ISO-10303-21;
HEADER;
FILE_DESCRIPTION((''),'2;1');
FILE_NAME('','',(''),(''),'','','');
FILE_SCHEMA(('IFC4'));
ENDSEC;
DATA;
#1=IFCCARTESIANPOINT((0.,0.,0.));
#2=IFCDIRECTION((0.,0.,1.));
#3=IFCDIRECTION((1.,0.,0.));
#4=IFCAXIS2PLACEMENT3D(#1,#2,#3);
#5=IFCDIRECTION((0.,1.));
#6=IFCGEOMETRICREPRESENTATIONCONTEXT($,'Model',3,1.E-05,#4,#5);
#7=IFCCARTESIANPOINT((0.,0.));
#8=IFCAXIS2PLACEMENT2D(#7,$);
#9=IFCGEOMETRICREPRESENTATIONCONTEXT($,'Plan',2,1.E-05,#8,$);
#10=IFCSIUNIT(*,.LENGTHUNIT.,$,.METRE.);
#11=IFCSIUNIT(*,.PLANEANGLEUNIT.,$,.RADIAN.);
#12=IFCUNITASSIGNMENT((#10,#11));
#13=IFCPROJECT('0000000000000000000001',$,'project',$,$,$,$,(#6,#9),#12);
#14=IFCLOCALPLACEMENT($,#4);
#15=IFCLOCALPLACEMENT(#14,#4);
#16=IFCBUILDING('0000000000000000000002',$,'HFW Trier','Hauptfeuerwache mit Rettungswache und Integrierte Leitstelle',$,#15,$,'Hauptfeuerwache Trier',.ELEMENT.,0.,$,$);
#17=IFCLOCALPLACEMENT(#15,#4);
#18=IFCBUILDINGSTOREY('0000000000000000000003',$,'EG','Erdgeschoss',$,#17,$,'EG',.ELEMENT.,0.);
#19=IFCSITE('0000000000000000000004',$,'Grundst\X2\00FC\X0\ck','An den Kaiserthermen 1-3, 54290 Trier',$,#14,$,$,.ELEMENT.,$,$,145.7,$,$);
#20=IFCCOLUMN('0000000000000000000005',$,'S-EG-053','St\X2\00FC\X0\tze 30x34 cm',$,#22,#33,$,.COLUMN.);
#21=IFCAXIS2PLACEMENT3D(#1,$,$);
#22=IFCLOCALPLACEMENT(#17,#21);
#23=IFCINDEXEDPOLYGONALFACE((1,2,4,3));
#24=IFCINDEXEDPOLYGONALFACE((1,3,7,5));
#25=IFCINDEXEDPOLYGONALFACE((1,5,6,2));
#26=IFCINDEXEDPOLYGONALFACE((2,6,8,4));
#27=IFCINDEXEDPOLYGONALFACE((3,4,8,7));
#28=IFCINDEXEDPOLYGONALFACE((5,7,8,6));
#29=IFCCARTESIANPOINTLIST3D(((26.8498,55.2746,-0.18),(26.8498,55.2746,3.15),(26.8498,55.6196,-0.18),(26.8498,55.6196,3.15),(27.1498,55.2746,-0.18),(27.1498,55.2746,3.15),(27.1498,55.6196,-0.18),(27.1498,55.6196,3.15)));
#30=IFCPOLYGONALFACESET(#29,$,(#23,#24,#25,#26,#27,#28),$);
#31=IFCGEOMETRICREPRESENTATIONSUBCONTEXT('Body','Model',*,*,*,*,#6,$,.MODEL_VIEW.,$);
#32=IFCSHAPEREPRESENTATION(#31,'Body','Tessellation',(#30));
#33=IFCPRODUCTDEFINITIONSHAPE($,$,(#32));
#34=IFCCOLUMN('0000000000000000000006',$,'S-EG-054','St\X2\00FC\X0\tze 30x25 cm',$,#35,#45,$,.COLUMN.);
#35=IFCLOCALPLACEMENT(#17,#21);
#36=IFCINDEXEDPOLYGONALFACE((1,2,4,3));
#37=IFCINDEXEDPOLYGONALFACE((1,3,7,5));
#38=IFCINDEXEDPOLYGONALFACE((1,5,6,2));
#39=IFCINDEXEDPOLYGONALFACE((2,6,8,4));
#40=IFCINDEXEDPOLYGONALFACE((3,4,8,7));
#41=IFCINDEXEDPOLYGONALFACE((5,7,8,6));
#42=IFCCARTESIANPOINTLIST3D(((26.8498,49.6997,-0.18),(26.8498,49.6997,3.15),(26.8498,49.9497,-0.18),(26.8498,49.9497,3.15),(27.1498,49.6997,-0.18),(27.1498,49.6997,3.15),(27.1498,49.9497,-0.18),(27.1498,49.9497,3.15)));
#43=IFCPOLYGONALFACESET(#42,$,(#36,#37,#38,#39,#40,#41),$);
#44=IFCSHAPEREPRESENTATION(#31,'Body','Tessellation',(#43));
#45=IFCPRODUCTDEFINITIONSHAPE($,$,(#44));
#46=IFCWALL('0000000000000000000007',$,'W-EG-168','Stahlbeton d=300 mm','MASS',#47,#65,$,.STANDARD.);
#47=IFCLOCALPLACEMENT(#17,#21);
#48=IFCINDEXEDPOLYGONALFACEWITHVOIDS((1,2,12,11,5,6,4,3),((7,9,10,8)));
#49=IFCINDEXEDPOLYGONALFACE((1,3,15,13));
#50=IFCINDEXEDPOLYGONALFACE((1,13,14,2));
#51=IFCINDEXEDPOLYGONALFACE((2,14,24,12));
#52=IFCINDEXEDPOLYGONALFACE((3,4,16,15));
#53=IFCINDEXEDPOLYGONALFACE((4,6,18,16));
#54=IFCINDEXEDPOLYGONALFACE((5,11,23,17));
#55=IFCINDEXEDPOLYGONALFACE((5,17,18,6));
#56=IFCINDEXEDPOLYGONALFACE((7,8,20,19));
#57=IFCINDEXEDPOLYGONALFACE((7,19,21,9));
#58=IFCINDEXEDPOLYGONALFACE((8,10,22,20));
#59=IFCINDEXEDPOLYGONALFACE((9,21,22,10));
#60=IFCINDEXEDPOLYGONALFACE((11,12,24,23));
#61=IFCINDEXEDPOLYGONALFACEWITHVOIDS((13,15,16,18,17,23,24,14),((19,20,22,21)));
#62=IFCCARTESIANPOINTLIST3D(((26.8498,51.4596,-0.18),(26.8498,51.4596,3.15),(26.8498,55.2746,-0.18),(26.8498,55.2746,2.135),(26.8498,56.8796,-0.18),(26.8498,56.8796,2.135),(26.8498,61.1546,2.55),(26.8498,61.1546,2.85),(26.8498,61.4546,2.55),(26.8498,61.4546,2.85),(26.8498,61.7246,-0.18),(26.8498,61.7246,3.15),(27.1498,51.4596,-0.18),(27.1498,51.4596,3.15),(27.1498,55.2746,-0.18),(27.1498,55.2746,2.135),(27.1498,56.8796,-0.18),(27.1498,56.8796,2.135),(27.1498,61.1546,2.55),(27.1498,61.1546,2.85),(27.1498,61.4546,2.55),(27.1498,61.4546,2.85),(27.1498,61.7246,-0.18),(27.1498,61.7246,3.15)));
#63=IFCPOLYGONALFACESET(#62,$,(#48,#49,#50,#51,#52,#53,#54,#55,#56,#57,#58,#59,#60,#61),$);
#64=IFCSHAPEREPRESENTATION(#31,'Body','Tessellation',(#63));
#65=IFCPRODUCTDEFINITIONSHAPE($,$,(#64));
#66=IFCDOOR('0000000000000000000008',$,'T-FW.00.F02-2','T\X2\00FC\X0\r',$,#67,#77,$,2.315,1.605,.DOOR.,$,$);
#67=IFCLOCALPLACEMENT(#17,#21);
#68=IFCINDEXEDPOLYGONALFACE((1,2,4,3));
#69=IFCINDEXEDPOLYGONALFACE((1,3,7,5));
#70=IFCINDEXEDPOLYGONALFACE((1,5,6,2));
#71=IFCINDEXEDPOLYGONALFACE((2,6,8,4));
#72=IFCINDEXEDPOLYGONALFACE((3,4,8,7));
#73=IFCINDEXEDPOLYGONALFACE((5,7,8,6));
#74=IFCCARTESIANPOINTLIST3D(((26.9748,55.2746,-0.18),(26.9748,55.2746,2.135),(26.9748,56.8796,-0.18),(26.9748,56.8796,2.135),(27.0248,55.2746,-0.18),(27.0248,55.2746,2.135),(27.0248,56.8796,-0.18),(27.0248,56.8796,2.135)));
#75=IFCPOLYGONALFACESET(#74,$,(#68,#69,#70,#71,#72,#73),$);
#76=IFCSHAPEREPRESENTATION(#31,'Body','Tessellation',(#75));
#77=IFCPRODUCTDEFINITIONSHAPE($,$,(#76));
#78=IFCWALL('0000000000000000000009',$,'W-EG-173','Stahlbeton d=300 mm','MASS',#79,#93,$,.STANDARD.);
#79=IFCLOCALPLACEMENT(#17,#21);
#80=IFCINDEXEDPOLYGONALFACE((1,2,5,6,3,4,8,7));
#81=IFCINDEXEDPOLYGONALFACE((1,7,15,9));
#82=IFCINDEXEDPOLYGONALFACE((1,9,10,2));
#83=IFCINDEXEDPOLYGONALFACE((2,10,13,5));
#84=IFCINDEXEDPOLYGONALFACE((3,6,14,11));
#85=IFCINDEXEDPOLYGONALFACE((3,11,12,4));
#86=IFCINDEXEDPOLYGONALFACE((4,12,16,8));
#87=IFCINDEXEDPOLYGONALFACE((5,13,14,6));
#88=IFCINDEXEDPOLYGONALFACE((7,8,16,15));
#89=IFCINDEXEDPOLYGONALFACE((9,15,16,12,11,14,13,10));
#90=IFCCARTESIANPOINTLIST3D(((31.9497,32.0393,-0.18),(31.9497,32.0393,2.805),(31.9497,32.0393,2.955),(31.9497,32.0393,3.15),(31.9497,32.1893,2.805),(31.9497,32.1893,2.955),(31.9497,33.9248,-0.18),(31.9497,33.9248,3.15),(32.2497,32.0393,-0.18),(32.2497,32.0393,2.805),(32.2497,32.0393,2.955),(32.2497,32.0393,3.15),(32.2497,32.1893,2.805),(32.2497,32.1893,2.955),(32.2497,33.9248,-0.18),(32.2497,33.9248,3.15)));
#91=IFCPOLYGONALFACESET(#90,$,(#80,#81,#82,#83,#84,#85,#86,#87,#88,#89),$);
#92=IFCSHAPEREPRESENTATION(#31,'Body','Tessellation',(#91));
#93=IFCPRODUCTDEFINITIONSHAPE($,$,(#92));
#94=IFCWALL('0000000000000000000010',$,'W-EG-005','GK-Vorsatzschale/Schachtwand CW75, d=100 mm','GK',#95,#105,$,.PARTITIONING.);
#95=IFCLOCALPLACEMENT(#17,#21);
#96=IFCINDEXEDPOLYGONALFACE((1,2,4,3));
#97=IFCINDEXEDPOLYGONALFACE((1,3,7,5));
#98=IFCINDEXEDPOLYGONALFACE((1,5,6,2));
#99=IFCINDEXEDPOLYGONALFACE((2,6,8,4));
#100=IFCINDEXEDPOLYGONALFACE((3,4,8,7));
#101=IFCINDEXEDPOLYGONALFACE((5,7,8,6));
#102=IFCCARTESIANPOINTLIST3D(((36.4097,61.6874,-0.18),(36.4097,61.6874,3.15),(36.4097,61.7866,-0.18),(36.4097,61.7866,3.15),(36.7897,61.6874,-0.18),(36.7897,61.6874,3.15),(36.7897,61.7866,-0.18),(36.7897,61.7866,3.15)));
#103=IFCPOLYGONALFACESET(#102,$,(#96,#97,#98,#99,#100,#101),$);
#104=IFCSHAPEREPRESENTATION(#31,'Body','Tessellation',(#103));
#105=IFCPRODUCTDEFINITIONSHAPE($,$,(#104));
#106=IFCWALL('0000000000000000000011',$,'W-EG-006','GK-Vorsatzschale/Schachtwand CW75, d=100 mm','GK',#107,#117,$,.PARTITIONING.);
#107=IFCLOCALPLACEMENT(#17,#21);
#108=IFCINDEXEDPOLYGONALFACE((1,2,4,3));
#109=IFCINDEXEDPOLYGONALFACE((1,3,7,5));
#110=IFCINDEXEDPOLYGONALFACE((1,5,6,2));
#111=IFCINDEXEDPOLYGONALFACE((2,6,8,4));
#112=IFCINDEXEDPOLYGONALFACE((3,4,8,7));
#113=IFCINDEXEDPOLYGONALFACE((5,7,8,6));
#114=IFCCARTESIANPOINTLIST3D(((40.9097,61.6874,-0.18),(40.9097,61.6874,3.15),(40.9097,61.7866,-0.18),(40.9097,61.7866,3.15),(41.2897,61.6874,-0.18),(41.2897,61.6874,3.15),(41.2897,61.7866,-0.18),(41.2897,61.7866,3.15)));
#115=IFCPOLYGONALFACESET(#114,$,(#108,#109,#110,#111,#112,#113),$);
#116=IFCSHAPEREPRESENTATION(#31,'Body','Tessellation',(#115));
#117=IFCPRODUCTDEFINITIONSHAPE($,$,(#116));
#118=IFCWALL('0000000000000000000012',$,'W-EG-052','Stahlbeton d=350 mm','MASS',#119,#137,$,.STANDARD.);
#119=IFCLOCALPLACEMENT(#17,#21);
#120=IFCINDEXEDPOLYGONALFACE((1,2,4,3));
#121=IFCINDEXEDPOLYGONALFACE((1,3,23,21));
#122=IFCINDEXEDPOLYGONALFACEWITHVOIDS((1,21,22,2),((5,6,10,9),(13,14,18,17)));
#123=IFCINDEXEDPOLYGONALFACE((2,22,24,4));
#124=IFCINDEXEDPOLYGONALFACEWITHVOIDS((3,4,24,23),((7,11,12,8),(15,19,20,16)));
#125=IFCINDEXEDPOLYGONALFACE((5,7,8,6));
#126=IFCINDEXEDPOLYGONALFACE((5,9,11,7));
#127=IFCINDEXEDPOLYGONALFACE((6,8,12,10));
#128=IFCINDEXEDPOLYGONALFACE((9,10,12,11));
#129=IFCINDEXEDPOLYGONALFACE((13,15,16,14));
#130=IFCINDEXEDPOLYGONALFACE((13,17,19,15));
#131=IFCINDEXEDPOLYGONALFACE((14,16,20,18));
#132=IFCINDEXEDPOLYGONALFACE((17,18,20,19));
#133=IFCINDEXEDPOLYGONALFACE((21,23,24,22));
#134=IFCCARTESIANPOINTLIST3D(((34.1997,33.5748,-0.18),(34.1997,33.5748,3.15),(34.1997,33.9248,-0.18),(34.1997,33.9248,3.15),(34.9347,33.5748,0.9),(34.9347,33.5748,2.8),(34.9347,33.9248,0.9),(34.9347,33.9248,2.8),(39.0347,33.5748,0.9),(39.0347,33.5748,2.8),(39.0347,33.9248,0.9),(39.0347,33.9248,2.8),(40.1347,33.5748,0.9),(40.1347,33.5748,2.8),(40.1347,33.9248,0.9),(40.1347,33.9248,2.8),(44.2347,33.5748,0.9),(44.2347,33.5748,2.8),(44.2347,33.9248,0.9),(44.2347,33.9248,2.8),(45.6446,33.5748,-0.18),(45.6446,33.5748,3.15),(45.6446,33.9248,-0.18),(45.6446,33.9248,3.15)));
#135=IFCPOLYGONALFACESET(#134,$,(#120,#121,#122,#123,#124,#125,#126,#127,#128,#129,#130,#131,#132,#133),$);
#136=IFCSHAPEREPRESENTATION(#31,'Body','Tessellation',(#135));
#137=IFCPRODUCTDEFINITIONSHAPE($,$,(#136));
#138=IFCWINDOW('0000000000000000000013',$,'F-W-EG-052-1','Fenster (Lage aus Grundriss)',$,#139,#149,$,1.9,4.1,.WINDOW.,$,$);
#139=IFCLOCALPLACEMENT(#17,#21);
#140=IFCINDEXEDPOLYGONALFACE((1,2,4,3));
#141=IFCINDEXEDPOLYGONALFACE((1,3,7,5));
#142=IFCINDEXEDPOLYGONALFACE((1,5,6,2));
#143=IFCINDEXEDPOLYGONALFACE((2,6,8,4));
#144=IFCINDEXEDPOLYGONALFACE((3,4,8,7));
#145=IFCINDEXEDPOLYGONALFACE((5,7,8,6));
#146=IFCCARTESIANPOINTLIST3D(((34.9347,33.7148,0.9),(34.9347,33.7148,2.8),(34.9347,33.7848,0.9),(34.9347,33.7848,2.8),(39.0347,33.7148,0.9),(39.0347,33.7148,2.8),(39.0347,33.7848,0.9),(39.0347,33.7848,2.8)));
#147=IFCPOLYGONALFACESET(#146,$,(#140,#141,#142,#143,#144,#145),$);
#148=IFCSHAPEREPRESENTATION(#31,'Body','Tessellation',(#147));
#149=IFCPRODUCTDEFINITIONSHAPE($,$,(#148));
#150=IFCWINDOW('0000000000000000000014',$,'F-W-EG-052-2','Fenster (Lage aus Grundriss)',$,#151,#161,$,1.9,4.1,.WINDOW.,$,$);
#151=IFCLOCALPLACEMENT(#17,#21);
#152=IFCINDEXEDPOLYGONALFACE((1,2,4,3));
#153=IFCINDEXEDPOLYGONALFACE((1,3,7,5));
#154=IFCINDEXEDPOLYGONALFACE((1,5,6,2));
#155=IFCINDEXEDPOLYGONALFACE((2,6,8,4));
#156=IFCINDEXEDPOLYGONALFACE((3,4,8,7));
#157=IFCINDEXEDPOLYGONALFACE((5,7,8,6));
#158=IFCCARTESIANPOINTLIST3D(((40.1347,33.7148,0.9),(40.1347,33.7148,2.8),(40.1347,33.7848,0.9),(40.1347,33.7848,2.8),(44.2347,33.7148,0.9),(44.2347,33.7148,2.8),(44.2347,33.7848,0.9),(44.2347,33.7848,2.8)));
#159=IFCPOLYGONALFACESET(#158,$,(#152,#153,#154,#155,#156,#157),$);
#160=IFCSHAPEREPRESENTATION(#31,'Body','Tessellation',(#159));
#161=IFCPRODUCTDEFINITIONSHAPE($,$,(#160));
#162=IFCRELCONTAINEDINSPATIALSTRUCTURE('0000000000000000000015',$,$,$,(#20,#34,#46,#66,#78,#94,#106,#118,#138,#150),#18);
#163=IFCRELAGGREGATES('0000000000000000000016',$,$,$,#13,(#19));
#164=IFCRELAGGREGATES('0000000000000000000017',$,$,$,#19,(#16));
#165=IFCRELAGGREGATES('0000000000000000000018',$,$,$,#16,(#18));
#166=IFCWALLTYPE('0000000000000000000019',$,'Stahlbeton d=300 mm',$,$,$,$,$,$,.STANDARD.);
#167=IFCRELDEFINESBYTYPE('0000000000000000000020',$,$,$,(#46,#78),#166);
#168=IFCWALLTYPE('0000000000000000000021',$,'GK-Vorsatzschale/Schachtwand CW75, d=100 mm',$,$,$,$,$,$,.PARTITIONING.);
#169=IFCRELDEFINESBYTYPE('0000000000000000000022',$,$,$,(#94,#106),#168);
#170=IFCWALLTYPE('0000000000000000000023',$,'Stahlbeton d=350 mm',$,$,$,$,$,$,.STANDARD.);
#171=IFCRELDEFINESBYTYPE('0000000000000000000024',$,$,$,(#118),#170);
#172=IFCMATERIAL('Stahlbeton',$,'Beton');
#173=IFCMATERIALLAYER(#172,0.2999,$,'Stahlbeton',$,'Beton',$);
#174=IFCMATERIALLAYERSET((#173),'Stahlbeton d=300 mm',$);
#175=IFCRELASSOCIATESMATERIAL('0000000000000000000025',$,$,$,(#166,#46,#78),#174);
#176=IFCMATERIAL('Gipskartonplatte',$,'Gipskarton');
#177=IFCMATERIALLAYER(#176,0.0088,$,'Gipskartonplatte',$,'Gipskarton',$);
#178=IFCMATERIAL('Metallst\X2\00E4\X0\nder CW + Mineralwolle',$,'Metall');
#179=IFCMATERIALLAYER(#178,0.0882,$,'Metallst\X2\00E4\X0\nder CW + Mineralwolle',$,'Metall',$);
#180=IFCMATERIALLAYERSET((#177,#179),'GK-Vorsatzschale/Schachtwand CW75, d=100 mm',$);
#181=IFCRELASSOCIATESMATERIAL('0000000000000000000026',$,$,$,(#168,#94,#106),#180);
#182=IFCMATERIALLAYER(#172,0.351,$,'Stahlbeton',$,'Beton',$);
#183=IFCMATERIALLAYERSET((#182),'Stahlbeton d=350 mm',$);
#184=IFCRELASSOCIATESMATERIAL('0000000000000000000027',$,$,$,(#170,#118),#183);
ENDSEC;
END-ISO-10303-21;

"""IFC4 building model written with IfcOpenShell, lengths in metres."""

from ifc_helpers import new_model, si_unit, direction, frame, frame_2d, origin_with_axes, origin_2d, place, context, subcontext, project, spatial, rectangle, extrude, material, layer, layer_set, layer_usage, type_object, element, fill, save


model = new_model("IFC4")

# Units and contexts
model_context = context("Model", 3, precision=1e-05, world=origin_with_axes(), true_north=direction((0.0, 1.0)))
plan_context = context("Plan", 2, precision=1e-05, world=origin_2d())
body_context = subcontext(model_context, "Body", "Model", "MODEL_VIEW")
ifc_project = project(units=[si_unit("LENGTHUNIT", "METRE"), si_unit("PLANEANGLEUNIT", "RADIAN")], contexts=[model_context, plan_context])

# Site, building, storey
site_placement = place(None, origin_with_axes())
site = spatial("IfcSite", under=ifc_project, at=site_placement, Name="Grundstück", Description="An den Kaiserthermen 1-3, 54290 Trier", CompositionType="ELEMENT", RefElevation=145.7)
building_placement = place(site_placement, origin_with_axes())
building = spatial("IfcBuilding", under=site, at=building_placement, Name="HFW Trier", Description="Hauptfeuerwache mit Rettungswache und Integrierte Leitstelle", LongName="Hauptfeuerwache Trier", CompositionType="ELEMENT", ElevationOfRefHeight=0.0)
storey_placement = place(building_placement, origin_with_axes())
storey = spatial("IfcBuildingStorey", under=building, at=storey_placement, Name="EG", Description="Erdgeschoss", LongName="EG", CompositionType="ELEMENT", Elevation=0.0)

# Columns
column_1_placement = place(storey_placement, frame((26.8498, 55.4471, -0.18), z_axis=(0.0, 0.0, 1.0), x_axis=(1.0, 0.0, 0.0)))
element("IfcColumn", 1, at=column_1_placement, inside=storey, Name="S-EG-053", Description="Stütze 30x34 cm", PredefinedType="COLUMN", context=body_context, shape_type="SweptSolid", body=[
    extrude(rectangle(XDim=0.3, YDim=0.345, at=frame_2d((0.15, 0.0))), origin_with_axes(), (0.0, 0.0, 1.0), 3.33),
])
column_2_placement = place(storey_placement, frame((26.8498, 49.8247, -0.18), z_axis=(0.0, 0.0, 1.0), x_axis=(1.0, 0.0, 0.0)))
element("IfcColumn", 2, at=column_2_placement, inside=storey, Name="S-EG-054", Description="Stütze 30x25 cm", PredefinedType="COLUMN", context=body_context, shape_type="SweptSolid", body=[
    extrude(rectangle(XDim=0.3, YDim=0.25, at=frame_2d((0.15, 0.0))), origin_with_axes(), (0.0, 0.0, 1.0), 3.33),
])

# Wall, openings, door
ifc_material_1 = material(Name="Stahlbeton", Category="Beton")
ifc_layer_1 = layer(ifc_material_1, 0.2999, Name="Stahlbeton", Category="Beton")
ifc_layer_set_1 = layer_set([ifc_layer_1], Name="Stahlbeton d=300 mm")
ifc_layer_usage_1 = layer_usage(ifc_layer_set_1, "AXIS2", "POSITIVE", -0.15)
wall_type_1 = type_object("IfcWallType", Name="Stahlbeton d=300 mm", PredefinedType="STANDARD", material=ifc_layer_set_1)
wall_1_placement = place(storey_placement, frame((26.9998, 61.7246, -0.18), z_axis=(0.0, 0.0, 1.0), x_axis=(0.0, -1.0, 0.0)))
wall_1 = element("IfcWall", 3, at=wall_1_placement, inside=storey, type_object=wall_type_1, material=ifc_layer_usage_1, Name="W-EG-168", Description="Stahlbeton d=300 mm", ObjectType="MASS", PredefinedType="STANDARD", context=body_context, shape_type="SweptSolid", body=[
    extrude(rectangle(XDim=10.265, YDim=0.3, at=frame_2d((5.1325, 0.0))), origin_with_axes(), (0.0, 0.0, 1.0), 3.33),
])
opening_1_placement = place(wall_1_placement, frame((4.845, 0.0, 0.0), z_axis=(0.0, 0.0, 1.0), x_axis=(1.0, 0.0, 0.0)))
opening_1 = element("IfcOpeningElement", 4, at=opening_1_placement, cuts=wall_1, PredefinedType="OPENING", context=body_context, shape_type="SweptSolid", body=[
    extrude(rectangle(XDim=1.605, YDim=0.4, at=frame_2d((0.8025, 0.0))), origin_with_axes(), (0.0, 0.0, 1.0), 2.315),
])
opening_2_placement = place(wall_1_placement, origin_with_axes())
element("IfcOpeningElement", 5, at=opening_2_placement, cuts=wall_1, ObjectType="Wanddurchbruch", PredefinedType="OPENING", context=body_context, shape_type="SweptSolid", body=[
    extrude(rectangle(XDim=0.3, YDim=0.4, at=frame_2d((0.42, 0.0))), frame((0.0, 0.0, 2.73), z_axis=(0.0, 0.0, 1.0), x_axis=(1.0, 0.0, 0.0)), (0.0, 0.0, 1.0), 0.3),
])
door_placement = place(wall_1_placement, frame((4.845, 0.0, 0.0), z_axis=(0.0, 0.0, 1.0), x_axis=(1.0, 0.0, 0.0)))
door = element("IfcDoor", 6, at=door_placement, inside=storey, Name="T-FW.00.F02-2", Description="Tür", OverallHeight=2.315, OverallWidth=1.605, PredefinedType="DOOR", context=body_context, shape_type="SweptSolid", body=[
    extrude(rectangle(XDim=1.605, YDim=0.05, at=frame_2d((0.8025, 0.0))), origin_with_axes(), (0.0, 0.0, 1.0), 2.315),
])
fill(opening_1, door)

# Wall, opening
ifc_layer_usage_2 = layer_usage(ifc_layer_set_1, "AXIS2", "POSITIVE", -0.15)
wall_2_placement = place(storey_placement, frame((32.0997, 33.9248, -0.18), z_axis=(0.0, 0.0, 1.0), x_axis=(0.0, -1.0, 0.0)))
wall_2 = element("IfcWall", 7, at=wall_2_placement, inside=storey, type_object=wall_type_1, material=ifc_layer_usage_2, Name="W-EG-173", Description="Stahlbeton d=300 mm", ObjectType="MASS", PredefinedType="STANDARD", context=body_context, shape_type="SweptSolid", body=[
    extrude(rectangle(XDim=1.8855, YDim=0.3, at=frame_2d((0.9428, 0.0))), origin_with_axes(), (0.0, 0.0, 1.0), 3.33),
])
opening_3_placement = place(wall_2_placement, origin_with_axes())
element("IfcOpeningElement", 8, at=opening_3_placement, cuts=wall_2, ObjectType="Wanddurchbruch", PredefinedType="OPENING", context=body_context, shape_type="SweptSolid", body=[
    extrude(rectangle(XDim=0.15, YDim=0.4, at=frame_2d((1.8105, 0.0))), frame((0.0, 0.0, 2.985), z_axis=(0.0, 0.0, 1.0), x_axis=(1.0, 0.0, 0.0)), (0.0, 0.0, 1.0), 0.15),
])

# Walls
ifc_material_2 = material(Name="Gipskartonplatte", Category="Gipskarton")
ifc_layer_2 = layer(ifc_material_2, 0.0088, Name="Gipskartonplatte", Category="Gipskarton")
ifc_material_3 = material(Name="Metallständer CW + Mineralwolle", Category="Metall")
ifc_layer_3 = layer(ifc_material_3, 0.0882, Name="Metallständer CW + Mineralwolle", Category="Metall")
ifc_layer_set_2 = layer_set([ifc_layer_2, ifc_layer_3], Name="GK-Vorsatzschale/Schachtwand CW75, d=100 mm")
ifc_layer_usage_3 = layer_usage(ifc_layer_set_2, "AXIS2", "POSITIVE", -0.0495)
wall_type_2 = type_object("IfcWallType", Name="GK-Vorsatzschale/Schachtwand CW75, d=100 mm", PredefinedType="PARTITIONING", material=ifc_layer_set_2)
wall_3_placement = place(storey_placement, frame((36.4097, 61.737, -0.18), z_axis=(0.0, 0.0, 1.0), x_axis=(1.0, 0.0, 0.0)))
element("IfcWall", 9, at=wall_3_placement, inside=storey, type_object=wall_type_2, material=ifc_layer_usage_3, Name="W-EG-005", Description="GK-Vorsatzschale/Schachtwand CW75, d=100 mm", ObjectType="GK", PredefinedType="PARTITIONING", context=body_context, shape_type="SweptSolid", body=[
    extrude(rectangle(XDim=0.38, YDim=0.0991, at=frame_2d((0.19, 0.0))), origin_with_axes(), (0.0, 0.0, 1.0), 3.33),
])
ifc_layer_usage_4 = layer_usage(ifc_layer_set_2, "AXIS2", "POSITIVE", -0.0495)
wall_4_placement = place(storey_placement, frame((40.9097, 61.737, -0.18), z_axis=(0.0, 0.0, 1.0), x_axis=(1.0, 0.0, 0.0)))
element("IfcWall", 10, at=wall_4_placement, inside=storey, type_object=wall_type_2, material=ifc_layer_usage_4, Name="W-EG-006", Description="GK-Vorsatzschale/Schachtwand CW75, d=100 mm", ObjectType="GK", PredefinedType="PARTITIONING", context=body_context, shape_type="SweptSolid", body=[
    extrude(rectangle(XDim=0.38, YDim=0.0991, at=frame_2d((0.19, 0.0))), origin_with_axes(), (0.0, 0.0, 1.0), 3.33),
])

# Wall, openings, windows
ifc_layer_4 = layer(ifc_material_1, 0.351, Name="Stahlbeton", Category="Beton")
ifc_layer_set_3 = layer_set([ifc_layer_4], Name="Stahlbeton d=350 mm")
ifc_layer_usage_5 = layer_usage(ifc_layer_set_3, "AXIS2", "POSITIVE", -0.175)
wall_type_3 = type_object("IfcWallType", Name="Stahlbeton d=350 mm", PredefinedType="STANDARD", material=ifc_layer_set_3)
wall_5_placement = place(storey_placement, frame((34.1997, 33.7498, -0.18), z_axis=(0.0, 0.0, 1.0), x_axis=(1.0, 0.0, 0.0)))
wall_5 = element("IfcWall", 11, at=wall_5_placement, inside=storey, type_object=wall_type_3, material=ifc_layer_usage_5, Name="W-EG-052", Description="Stahlbeton d=350 mm", ObjectType="MASS", PredefinedType="STANDARD", context=body_context, shape_type="SweptSolid", body=[
    extrude(rectangle(XDim=11.4449, YDim=0.35, at=frame_2d((5.7224, 0.0))), origin_with_axes(), (0.0, 0.0, 1.0), 3.33),
])
opening_4_placement = place(wall_5_placement, frame((0.735, 0.0, 0.0), z_axis=(0.0, 0.0, 1.0), x_axis=(1.0, 0.0, 0.0)))
opening_4 = element("IfcOpeningElement", 12, at=opening_4_placement, cuts=wall_5, PredefinedType="OPENING", context=body_context, shape_type="SweptSolid", body=[
    extrude(rectangle(XDim=4.1, YDim=0.45, at=frame_2d((2.05, 0.0))), frame((0.0, 0.0, 1.08), z_axis=(0.0, 0.0, 1.0), x_axis=(1.0, 0.0, 0.0)), (0.0, 0.0, 1.0), 1.9),
])
opening_5_placement = place(wall_5_placement, frame((5.935, 0.0, 0.0), z_axis=(0.0, 0.0, 1.0), x_axis=(1.0, 0.0, 0.0)))
opening_5 = element("IfcOpeningElement", 13, at=opening_5_placement, cuts=wall_5, PredefinedType="OPENING", context=body_context, shape_type="SweptSolid", body=[
    extrude(rectangle(XDim=4.1, YDim=0.45, at=frame_2d((2.05, 0.0))), frame((0.0, 0.0, 1.08), z_axis=(0.0, 0.0, 1.0), x_axis=(1.0, 0.0, 0.0)), (0.0, 0.0, 1.0), 1.9),
])
window_1_placement = place(wall_5_placement, frame((0.735, 0.0, 0.0), z_axis=(0.0, 0.0, 1.0), x_axis=(1.0, 0.0, 0.0)))
window_1 = element("IfcWindow", 14, at=window_1_placement, inside=storey, Name="F-W-EG-052-1", Description="Fenster (Lage aus Grundriss)", OverallHeight=1.9, OverallWidth=4.1, PredefinedType="WINDOW", context=body_context, shape_type="SweptSolid", body=[
    extrude(rectangle(XDim=4.1, YDim=0.07, at=frame_2d((2.05, 0.0))), frame((0.0, 0.0, 1.08), z_axis=(0.0, 0.0, 1.0), x_axis=(1.0, 0.0, 0.0)), (0.0, 0.0, 1.0), 1.9),
])
fill(opening_4, window_1)
window_2_placement = place(wall_5_placement, frame((5.935, 0.0, 0.0), z_axis=(0.0, 0.0, 1.0), x_axis=(1.0, 0.0, 0.0)))
window_2 = element("IfcWindow", 15, at=window_2_placement, inside=storey, Name="F-W-EG-052-2", Description="Fenster (Lage aus Grundriss)", OverallHeight=1.9, OverallWidth=4.1, PredefinedType="WINDOW", context=body_context, shape_type="SweptSolid", body=[
    extrude(rectangle(XDim=4.1, YDim=0.07, at=frame_2d((2.05, 0.0))), frame((0.0, 0.0, 1.08), z_axis=(0.0, 0.0, 1.0), x_axis=(1.0, 0.0, 0.0)), (0.0, 0.0, 1.0), 1.9),
])
fill(opening_5, window_2)

save(model, "model.ifc")
